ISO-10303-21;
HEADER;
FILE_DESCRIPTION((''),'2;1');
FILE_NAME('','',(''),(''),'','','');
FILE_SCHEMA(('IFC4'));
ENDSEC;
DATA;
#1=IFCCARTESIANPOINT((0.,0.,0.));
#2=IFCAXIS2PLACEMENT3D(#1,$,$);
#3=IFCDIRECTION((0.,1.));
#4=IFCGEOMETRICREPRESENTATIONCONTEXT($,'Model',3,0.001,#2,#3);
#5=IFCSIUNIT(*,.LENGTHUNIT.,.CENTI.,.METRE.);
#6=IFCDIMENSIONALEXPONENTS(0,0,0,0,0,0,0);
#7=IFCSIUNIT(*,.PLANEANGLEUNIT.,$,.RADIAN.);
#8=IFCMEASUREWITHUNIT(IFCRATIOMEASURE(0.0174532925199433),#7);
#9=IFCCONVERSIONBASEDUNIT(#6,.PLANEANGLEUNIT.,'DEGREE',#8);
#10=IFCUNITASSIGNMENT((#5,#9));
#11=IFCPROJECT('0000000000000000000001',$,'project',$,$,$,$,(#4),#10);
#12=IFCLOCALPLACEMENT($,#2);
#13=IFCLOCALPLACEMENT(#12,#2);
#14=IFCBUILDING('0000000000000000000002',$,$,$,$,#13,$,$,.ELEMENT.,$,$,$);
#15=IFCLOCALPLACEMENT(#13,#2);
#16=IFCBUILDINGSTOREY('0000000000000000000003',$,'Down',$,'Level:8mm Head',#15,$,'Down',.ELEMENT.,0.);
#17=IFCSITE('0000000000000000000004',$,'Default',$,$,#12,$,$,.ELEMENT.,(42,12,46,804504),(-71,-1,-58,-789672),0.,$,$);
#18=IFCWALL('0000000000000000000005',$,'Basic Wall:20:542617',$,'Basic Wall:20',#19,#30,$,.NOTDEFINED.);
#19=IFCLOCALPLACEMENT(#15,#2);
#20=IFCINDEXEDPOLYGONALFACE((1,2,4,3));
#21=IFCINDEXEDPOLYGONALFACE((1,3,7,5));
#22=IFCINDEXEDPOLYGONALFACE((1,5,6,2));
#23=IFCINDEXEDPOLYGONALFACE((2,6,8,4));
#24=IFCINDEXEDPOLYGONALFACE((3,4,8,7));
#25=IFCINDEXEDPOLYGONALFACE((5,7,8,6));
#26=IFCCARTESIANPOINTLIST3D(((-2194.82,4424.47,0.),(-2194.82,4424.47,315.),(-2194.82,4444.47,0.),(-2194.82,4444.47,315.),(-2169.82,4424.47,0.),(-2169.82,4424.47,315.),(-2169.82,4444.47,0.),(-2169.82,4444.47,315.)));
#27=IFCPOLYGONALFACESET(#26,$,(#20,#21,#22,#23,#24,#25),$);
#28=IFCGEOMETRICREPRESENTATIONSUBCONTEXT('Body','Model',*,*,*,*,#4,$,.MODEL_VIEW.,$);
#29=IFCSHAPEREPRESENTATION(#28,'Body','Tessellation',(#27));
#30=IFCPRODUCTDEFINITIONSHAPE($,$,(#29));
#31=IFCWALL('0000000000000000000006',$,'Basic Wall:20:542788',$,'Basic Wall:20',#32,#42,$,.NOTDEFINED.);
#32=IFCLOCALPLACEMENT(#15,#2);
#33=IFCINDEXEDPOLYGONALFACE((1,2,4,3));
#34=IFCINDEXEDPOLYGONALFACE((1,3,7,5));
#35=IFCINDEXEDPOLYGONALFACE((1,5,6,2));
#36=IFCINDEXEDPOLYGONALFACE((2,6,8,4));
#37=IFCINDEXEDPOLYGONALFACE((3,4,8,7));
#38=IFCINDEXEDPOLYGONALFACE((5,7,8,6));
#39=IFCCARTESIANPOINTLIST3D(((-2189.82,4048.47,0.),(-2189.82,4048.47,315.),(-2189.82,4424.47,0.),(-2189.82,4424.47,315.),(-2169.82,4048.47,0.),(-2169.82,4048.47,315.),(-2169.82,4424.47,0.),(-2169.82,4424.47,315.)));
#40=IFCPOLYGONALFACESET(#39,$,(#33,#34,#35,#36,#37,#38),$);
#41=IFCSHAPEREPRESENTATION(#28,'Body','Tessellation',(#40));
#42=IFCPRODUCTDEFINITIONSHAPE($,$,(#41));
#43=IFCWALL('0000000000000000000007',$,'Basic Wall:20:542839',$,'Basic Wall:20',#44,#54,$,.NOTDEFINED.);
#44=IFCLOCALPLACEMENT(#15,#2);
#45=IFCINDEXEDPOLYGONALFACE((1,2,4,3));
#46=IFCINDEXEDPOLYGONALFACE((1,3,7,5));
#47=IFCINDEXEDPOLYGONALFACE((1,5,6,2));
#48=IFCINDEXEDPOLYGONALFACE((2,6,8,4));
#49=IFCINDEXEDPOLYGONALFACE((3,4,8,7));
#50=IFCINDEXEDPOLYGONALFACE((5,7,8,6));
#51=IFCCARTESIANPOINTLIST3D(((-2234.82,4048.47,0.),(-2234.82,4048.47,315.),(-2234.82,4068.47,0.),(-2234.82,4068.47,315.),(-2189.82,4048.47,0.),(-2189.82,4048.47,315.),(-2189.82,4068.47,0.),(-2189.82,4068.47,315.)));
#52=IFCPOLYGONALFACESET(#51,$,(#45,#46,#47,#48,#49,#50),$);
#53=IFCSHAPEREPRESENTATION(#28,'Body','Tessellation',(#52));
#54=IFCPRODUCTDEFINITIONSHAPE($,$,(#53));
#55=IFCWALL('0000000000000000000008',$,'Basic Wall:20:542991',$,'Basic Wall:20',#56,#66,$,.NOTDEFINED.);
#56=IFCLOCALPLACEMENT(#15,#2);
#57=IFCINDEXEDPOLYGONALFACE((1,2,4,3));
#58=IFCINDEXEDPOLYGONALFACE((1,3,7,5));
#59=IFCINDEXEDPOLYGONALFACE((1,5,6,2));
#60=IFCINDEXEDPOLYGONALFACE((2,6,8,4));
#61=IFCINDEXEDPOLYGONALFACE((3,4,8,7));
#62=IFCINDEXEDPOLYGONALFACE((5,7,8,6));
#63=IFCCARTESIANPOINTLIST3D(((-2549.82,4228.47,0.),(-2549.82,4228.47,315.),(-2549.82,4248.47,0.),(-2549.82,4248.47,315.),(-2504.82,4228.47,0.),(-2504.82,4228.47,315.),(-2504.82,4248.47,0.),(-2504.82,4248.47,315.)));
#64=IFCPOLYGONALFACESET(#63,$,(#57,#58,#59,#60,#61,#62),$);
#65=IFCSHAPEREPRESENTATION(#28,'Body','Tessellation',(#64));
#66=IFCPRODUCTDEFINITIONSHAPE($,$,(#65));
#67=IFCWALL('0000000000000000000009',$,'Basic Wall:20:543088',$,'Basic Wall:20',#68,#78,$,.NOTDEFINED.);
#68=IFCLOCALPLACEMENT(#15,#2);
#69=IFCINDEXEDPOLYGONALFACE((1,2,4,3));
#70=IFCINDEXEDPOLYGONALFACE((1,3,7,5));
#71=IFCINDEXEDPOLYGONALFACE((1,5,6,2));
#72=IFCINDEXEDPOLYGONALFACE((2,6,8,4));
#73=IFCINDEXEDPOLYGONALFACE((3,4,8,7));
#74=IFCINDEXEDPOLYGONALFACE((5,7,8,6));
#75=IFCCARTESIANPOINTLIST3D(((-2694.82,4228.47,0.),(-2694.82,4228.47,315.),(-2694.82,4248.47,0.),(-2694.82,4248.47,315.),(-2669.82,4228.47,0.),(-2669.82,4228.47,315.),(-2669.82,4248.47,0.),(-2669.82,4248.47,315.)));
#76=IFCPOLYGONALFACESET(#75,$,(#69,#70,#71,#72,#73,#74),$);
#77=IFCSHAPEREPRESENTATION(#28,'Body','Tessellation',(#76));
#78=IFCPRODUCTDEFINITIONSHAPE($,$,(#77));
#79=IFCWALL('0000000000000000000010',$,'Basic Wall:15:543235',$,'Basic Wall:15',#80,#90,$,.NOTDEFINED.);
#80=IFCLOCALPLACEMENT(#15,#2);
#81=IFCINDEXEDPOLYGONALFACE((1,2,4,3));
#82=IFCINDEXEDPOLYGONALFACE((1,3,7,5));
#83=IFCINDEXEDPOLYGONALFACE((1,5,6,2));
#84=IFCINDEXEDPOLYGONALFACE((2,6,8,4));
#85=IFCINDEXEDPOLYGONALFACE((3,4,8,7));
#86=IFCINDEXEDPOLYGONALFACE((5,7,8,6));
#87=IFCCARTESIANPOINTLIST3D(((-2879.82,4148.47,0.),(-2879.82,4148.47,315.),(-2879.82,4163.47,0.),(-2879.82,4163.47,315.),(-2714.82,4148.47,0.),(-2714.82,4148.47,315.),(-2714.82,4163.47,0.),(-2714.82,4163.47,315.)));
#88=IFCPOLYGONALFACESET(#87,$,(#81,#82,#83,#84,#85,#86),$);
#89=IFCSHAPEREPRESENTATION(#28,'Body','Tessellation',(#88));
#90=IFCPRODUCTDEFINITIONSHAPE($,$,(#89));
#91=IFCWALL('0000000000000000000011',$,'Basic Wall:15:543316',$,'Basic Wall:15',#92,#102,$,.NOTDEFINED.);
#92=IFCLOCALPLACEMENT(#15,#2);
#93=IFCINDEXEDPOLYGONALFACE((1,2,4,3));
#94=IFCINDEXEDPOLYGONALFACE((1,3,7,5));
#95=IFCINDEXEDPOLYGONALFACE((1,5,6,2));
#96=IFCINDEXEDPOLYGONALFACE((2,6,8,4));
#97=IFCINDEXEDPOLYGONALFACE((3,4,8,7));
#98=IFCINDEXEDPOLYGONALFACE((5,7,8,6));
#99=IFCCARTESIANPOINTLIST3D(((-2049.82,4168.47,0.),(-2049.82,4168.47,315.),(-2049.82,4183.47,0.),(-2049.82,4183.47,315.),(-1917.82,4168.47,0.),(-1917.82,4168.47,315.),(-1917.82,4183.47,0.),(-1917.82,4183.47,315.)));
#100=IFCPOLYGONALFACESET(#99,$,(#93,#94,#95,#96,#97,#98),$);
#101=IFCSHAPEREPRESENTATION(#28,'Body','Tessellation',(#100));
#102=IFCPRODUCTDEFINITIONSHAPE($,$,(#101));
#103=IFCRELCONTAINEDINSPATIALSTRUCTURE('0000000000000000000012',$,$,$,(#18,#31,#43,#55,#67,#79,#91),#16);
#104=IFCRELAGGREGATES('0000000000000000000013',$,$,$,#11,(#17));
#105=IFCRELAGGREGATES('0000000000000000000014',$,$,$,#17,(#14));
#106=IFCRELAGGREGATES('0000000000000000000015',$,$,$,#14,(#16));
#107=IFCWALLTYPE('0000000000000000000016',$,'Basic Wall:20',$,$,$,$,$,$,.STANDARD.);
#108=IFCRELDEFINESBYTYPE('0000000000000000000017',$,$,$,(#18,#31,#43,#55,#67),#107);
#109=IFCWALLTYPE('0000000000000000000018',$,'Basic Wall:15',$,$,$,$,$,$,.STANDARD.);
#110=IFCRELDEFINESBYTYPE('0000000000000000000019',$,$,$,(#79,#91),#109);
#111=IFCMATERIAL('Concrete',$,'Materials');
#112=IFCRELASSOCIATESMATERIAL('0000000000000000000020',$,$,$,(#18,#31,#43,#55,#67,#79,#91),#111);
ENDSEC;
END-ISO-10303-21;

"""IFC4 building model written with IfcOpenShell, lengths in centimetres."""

from ifc_helpers import new_model, entity, si_unit, converted_unit, direction, frame, origin, place, context, subcontext, project, spatial, indexed_curve, outline, extrude, material, type_object, element, save


model = new_model("IFC4")

# Units and contexts
model_context = context("Model", 3, precision=0.001, world=origin(), true_north=direction((0.0, 1.0)))
body_context = subcontext(model_context, "Body", "Model", "MODEL_VIEW")
ifc_project = project(units=[si_unit("LENGTHUNIT", "METRE", prefix="CENTI"), converted_unit("PLANEANGLEUNIT", "DEGREE", entity("IfcRatioMeasure", 0.0174532925199433), si_unit("PLANEANGLEUNIT", "RADIAN"), dimensions=[0, 0, 0, 0, 0, 0, 0])], contexts=[model_context])

# Site, building, storey
site_placement = place(None, origin())
site = spatial("IfcSite", under=ifc_project, at=site_placement, Name="Default", CompositionType="ELEMENT", RefLatitude=(42, 12, 46, 804504), RefLongitude=(-71, -1, -58, -789672), RefElevation=0.0)
building_placement = place(site_placement, origin())
building = spatial("IfcBuilding", under=site, at=building_placement, CompositionType="ELEMENT")
storey_placement = place(building_placement, origin())
storey = spatial("IfcBuildingStorey", under=building, at=storey_placement, Name="Down", ObjectType="Level:8mm Head", LongName="Down", CompositionType="ELEMENT", Elevation=0.0)

# Shared definitions
ifc_material = material(Name="Concrete", Category="Materials")

# Walls
wall_type_1 = type_object("IfcWallType", Name="Basic Wall:20", PredefinedType="STANDARD")
wall_1_placement = place(storey_placement, frame((-2194.82, 4434.47, 0.0)))
element("IfcWall", 1, at=wall_1_placement, inside=storey, type_object=wall_type_1, material=ifc_material, Name="Basic Wall:20:542617", ObjectType="Basic Wall:20", PredefinedType="NOTDEFINED", context=body_context, shape_type="SweptSolid", body=[
    extrude(outline(indexed_curve([(25.0, 10.0), (0.0, 10.0), (0.0, -10.0), (25.0, -10.0), (25.0, 10.0)], self_intersect=False)), origin(), (0.0, 0.0, 1.0), 315.0),
])
wall_2_placement = place(storey_placement, frame((-2179.82, 4424.47, 0.0), z_axis=(0.0, 0.0, 1.0), x_axis=(0.0, -1.0, 0.0)))
element("IfcWall", 2, at=wall_2_placement, inside=storey, type_object=wall_type_1, material=ifc_material, Name="Basic Wall:20:542788", ObjectType="Basic Wall:20", PredefinedType="NOTDEFINED", context=body_context, shape_type="SweptSolid", body=[
    extrude(outline(indexed_curve([(376.0, 10.0), (0.0, 10.0), (0.0, -10.0), (376.0, -10.0), (376.0, 10.0)], self_intersect=False)), origin(), (0.0, 0.0, 1.0), 315.0),
])
wall_3_placement = place(storey_placement, frame((-2189.82, 4058.47, 0.0), z_axis=(0.0, 0.0, 1.0), x_axis=(-1.0, 0.0, 0.0)))
element("IfcWall", 3, at=wall_3_placement, inside=storey, type_object=wall_type_1, material=ifc_material, Name="Basic Wall:20:542839", ObjectType="Basic Wall:20", PredefinedType="NOTDEFINED", context=body_context, shape_type="SweptSolid", body=[
    extrude(outline(indexed_curve([(45.0, 10.0), (0.0, 10.0), (0.0, -10.0), (45.0, -10.0), (45.0, 10.0)], self_intersect=False)), origin(), (0.0, 0.0, 1.0), 315.0),
])
wall_4_placement = place(storey_placement, frame((-2504.82, 4238.47, 0.0), z_axis=(0.0, 0.0, 1.0), x_axis=(-1.0, 0.0, 0.0)))
element("IfcWall", 4, at=wall_4_placement, inside=storey, type_object=wall_type_1, material=ifc_material, Name="Basic Wall:20:542991", ObjectType="Basic Wall:20", PredefinedType="NOTDEFINED", context=body_context, shape_type="SweptSolid", body=[
    extrude(outline(indexed_curve([(45.0, 10.0), (0.0, 10.0), (0.0, -10.0), (45.0, -10.0), (45.0, 10.0)], self_intersect=False)), origin(), (0.0, 0.0, 1.0), 315.0),
])
wall_5_placement = place(storey_placement, frame((-2669.82, 4238.47, 0.0), z_axis=(0.0, 0.0, 1.0), x_axis=(-1.0, 0.0, 0.0)))
element("IfcWall", 5, at=wall_5_placement, inside=storey, type_object=wall_type_1, material=ifc_material, Name="Basic Wall:20:543088", ObjectType="Basic Wall:20", PredefinedType="NOTDEFINED", context=body_context, shape_type="SweptSolid", body=[
    extrude(outline(indexed_curve([(25.0, 10.0), (0.0, 10.0), (0.0, -10.0), (25.0, -10.0), (25.0, 10.0)], self_intersect=False)), origin(), (0.0, 0.0, 1.0), 315.0),
])
wall_type_2 = type_object("IfcWallType", Name="Basic Wall:15", PredefinedType="STANDARD")
wall_6_placement = place(storey_placement, frame((-2879.82, 4155.97, 0.0)))
element("IfcWall", 6, at=wall_6_placement, inside=storey, type_object=wall_type_2, material=ifc_material, Name="Basic Wall:15:543235", ObjectType="Basic Wall:15", PredefinedType="NOTDEFINED", context=body_context, shape_type="SweptSolid", body=[
    extrude(outline(indexed_curve([(165.0, 7.5), (0.0, 7.5), (0.0, -7.5), (165.0, -7.5), (165.0, 7.5)], self_intersect=False)), origin(), (0.0, 0.0, 1.0), 315.0),
])
wall_7_placement = place(storey_placement, frame((-1917.82, 4175.97, 0.0), z_axis=(0.0, 0.0, 1.0), x_axis=(-1.0, 0.0, 0.0)))
element("IfcWall", 7, at=wall_7_placement, inside=storey, type_object=wall_type_2, material=ifc_material, Name="Basic Wall:15:543316", ObjectType="Basic Wall:15", PredefinedType="NOTDEFINED", context=body_context, shape_type="SweptSolid", body=[
    extrude(outline(indexed_curve([(132.0, 7.5), (0.0, 7.5), (0.0, -7.5), (132.0, -7.5), (132.0, 7.5)], self_intersect=False)), origin(), (0.0, 0.0, 1.0), 315.0),
])

save(model, "model.ifc")
